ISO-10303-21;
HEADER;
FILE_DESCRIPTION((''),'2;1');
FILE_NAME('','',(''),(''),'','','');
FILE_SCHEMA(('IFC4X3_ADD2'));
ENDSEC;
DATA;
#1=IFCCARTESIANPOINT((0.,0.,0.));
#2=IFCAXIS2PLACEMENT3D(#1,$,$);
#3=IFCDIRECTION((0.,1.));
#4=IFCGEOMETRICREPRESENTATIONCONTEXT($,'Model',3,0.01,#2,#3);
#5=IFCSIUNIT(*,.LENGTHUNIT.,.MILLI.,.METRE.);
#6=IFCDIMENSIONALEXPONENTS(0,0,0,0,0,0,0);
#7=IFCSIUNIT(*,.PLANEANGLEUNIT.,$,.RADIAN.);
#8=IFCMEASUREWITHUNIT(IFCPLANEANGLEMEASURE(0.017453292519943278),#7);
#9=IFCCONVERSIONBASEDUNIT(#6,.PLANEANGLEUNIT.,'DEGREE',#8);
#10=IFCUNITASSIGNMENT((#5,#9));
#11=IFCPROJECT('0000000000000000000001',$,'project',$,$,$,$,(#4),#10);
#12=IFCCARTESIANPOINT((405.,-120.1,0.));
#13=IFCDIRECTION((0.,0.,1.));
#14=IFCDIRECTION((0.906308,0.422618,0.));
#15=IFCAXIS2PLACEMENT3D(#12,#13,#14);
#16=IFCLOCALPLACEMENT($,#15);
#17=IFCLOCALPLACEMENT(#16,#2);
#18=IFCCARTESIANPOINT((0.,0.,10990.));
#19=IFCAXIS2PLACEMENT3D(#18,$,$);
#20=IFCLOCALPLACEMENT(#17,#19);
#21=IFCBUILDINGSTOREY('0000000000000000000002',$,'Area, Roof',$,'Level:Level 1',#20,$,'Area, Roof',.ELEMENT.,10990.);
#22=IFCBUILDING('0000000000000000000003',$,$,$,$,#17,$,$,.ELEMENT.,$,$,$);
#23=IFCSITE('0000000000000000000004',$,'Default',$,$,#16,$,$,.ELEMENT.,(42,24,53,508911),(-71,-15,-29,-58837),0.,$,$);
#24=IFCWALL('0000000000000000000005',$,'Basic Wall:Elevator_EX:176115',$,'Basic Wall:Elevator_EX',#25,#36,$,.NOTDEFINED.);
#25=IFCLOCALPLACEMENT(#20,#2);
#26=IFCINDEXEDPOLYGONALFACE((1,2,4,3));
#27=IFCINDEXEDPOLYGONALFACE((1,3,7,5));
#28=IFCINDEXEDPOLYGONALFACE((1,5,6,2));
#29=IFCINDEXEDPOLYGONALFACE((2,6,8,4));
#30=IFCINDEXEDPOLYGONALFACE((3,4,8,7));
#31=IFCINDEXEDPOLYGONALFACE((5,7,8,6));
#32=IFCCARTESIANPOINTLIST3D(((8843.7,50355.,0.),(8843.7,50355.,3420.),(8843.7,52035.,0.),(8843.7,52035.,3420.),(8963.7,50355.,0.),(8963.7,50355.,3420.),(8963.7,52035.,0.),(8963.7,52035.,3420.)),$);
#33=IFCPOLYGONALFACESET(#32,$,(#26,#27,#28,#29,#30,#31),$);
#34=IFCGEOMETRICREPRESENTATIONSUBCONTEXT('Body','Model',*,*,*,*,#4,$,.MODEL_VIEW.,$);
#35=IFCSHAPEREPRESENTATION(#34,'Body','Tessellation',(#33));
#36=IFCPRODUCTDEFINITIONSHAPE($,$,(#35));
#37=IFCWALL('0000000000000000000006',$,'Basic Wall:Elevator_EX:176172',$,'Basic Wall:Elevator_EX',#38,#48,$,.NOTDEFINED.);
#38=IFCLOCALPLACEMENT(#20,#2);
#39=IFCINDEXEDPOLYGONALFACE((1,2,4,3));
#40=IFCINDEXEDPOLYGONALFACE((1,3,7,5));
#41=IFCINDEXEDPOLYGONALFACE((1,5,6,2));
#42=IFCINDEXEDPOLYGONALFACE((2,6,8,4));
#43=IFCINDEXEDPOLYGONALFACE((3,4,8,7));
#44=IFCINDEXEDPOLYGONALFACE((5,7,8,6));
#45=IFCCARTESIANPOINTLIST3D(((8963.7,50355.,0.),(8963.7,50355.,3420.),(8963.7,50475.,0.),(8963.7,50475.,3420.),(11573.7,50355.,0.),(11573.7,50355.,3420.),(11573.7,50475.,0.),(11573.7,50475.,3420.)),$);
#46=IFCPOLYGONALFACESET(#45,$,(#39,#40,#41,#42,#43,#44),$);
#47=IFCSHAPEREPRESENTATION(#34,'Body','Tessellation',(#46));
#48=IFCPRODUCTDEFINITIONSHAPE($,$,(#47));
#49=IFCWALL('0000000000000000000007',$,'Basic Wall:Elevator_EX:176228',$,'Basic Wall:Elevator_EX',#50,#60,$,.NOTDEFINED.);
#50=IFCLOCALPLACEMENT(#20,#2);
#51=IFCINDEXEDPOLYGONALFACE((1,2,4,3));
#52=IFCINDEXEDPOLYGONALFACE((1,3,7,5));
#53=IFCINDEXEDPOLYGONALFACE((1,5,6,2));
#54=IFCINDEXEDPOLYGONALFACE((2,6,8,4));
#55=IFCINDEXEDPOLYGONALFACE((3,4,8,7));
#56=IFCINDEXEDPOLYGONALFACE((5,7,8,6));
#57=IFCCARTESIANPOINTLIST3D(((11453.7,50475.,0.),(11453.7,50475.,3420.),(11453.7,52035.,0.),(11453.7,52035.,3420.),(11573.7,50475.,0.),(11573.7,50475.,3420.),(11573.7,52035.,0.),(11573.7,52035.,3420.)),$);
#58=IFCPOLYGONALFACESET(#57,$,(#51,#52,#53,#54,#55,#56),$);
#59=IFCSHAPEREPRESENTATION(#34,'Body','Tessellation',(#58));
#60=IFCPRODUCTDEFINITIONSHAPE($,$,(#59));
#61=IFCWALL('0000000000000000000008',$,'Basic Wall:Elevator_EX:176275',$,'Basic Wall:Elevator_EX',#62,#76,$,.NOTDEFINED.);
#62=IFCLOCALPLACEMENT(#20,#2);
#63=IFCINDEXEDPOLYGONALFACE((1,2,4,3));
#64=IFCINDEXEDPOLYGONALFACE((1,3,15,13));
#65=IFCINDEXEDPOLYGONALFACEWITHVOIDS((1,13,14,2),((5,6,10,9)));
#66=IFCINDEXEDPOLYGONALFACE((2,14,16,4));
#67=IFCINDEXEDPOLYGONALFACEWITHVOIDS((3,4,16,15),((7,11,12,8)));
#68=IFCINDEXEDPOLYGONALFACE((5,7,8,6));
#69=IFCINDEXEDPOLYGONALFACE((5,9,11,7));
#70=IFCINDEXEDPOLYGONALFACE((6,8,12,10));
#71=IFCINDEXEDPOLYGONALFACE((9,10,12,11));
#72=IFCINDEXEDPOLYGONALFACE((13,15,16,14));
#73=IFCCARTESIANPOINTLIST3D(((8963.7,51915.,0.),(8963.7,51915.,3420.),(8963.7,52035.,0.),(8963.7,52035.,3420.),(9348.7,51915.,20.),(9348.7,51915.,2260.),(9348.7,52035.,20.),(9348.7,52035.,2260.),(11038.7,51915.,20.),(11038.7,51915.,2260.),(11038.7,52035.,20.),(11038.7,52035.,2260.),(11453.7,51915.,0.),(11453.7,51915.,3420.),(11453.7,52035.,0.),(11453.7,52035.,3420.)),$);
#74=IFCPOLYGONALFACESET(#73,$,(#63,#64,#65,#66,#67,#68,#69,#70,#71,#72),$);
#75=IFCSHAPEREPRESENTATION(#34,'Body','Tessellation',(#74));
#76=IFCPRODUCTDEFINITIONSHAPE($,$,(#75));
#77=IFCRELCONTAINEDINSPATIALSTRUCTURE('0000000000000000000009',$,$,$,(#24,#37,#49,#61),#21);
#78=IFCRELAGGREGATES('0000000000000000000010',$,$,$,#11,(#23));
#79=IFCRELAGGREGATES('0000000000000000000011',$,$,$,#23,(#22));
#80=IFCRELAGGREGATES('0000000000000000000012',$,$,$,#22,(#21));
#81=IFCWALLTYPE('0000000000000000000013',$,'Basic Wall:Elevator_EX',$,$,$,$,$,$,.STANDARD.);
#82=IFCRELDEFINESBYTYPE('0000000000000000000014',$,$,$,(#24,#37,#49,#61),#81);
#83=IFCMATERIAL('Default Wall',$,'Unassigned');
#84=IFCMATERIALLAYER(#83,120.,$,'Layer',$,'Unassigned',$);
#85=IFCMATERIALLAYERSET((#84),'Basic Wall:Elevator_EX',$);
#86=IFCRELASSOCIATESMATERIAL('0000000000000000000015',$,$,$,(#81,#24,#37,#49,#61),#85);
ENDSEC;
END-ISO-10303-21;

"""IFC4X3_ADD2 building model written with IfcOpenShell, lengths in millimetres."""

from ifc_helpers import new_model, entity, si_unit, converted_unit, direction, frame, frame_2d, origin, place, context, subcontext, project, spatial, rectangle, extrude, material, layer, layer_set, type_object, element, save


model = new_model("IFC4X3_ADD2")

# Units and contexts
model_context = context("Model", 3, precision=0.01, world=origin(), true_north=direction((0.0, 1.0)))
body_context = subcontext(model_context, "Body", "Model", "MODEL_VIEW")
ifc_project = project(units=[si_unit("LENGTHUNIT", "METRE", prefix="MILLI"), converted_unit("PLANEANGLEUNIT", "DEGREE", entity("IfcPlaneAngleMeasure", 0.017453292519943278), si_unit("PLANEANGLEUNIT", "RADIAN"), dimensions=[0, 0, 0, 0, 0, 0, 0])], contexts=[model_context])

# Site, building, storey
site_placement = place(None, frame((405.0, -120.1, 0.0), z_axis=(0.0, 0.0, 1.0), x_axis=(0.906308, 0.422618, 0.0)))
site = spatial("IfcSite", under=ifc_project, at=site_placement, Name="Default", CompositionType="ELEMENT", RefLatitude=(42, 24, 53, 508911), RefLongitude=(-71, -15, -29, -58837), RefElevation=0.0)
building_placement = place(site_placement, origin())
building = spatial("IfcBuilding", under=site, at=building_placement, CompositionType="ELEMENT")
storey_placement = place(building_placement, frame((0.0, 0.0, 10990.0)))
storey = spatial("IfcBuildingStorey", under=building, at=storey_placement, Name="Area, Roof", ObjectType="Level:Level 1", LongName="Area, Roof", CompositionType="ELEMENT", Elevation=10990.0)

# Shared definitions
ifc_material_1 = material(Name="Default Wall", Category="Unassigned")

# Walls
ifc_layer_1 = layer(ifc_material_1, 120.0, Name="Layer", Category="Unassigned")
ifc_layer_set_1 = layer_set([ifc_layer_1], Name="Basic Wall:Elevator_EX")
wall_type_1 = type_object("IfcWallType", Name="Basic Wall:Elevator_EX", PredefinedType="STANDARD", material=ifc_layer_set_1)
wall_1_placement = place(storey_placement, frame((8903.7, 52035.0, 0.0), z_axis=(0.0, 0.0, 1.0), x_axis=(0.0, -1.0, 0.0)))
element("IfcWall", 1, at=wall_1_placement, inside=storey, type_object=wall_type_1, material=ifc_layer_set_1, Name="Basic Wall:Elevator_EX:176115", ObjectType="Basic Wall:Elevator_EX", PredefinedType="NOTDEFINED", context=body_context, shape_type="SweptSolid", body=[
    extrude(rectangle(XDim=1680.0, YDim=120.0, at=frame_2d((840.0, 0.0), x_axis=(-1.0, 0.0))), origin(), (0.0, 0.0, 1.0), 3420.0),
])
wall_2_placement = place(storey_placement, frame((8963.7, 50415.0, 0.0)))
element("IfcWall", 2, at=wall_2_placement, inside=storey, type_object=wall_type_1, material=ifc_layer_set_1, Name="Basic Wall:Elevator_EX:176172", ObjectType="Basic Wall:Elevator_EX", PredefinedType="NOTDEFINED", context=body_context, shape_type="SweptSolid", body=[
    extrude(rectangle(XDim=2610.0, YDim=120.0, at=frame_2d((1305.0, 0.0), x_axis=(-1.0, 0.0))), origin(), (0.0, 0.0, 1.0), 3420.0),
])
wall_3_placement = place(storey_placement, frame((11513.7, 52035.0, 0.0), z_axis=(0.0, 0.0, 1.0), x_axis=(0.0, -1.0, 0.0)))
element("IfcWall", 3, at=wall_3_placement, inside=storey, type_object=wall_type_1, material=ifc_layer_set_1, Name="Basic Wall:Elevator_EX:176228", ObjectType="Basic Wall:Elevator_EX", PredefinedType="NOTDEFINED", context=body_context, shape_type="SweptSolid", body=[
    extrude(rectangle(XDim=1560.0, YDim=120.0, at=frame_2d((780.0, 0.0), x_axis=(-1.0, 0.0))), origin(), (0.0, 0.0, 1.0), 3420.0),
])

# Wall, opening
wall_4_placement = place(storey_placement, frame((8963.7, 51975.0, 0.0)))
wall_4 = element("IfcWall", 4, at=wall_4_placement, inside=storey, type_object=wall_type_1, material=ifc_layer_set_1, Name="Basic Wall:Elevator_EX:176275", ObjectType="Basic Wall:Elevator_EX", PredefinedType="NOTDEFINED", context=body_context, shape_type="SweptSolid", body=[
    extrude(rectangle(XDim=2490.0, YDim=120.0, at=frame_2d((1245.0, 0.0), x_axis=(-1.0, 0.0))), origin(), (0.0, 0.0, 1.0), 3420.0),
])
opening_1_placement = place(wall_4_placement, frame((385.0, -60.0, 20.0)))
element("IfcOpeningElement", 5, at=opening_1_placement, cuts=wall_4, PredefinedType="OPENING", context=body_context, shape_type="SweptSolid", body=[
    extrude(rectangle(XDim=2240.0, YDim=1690.0, at=frame_2d((0.0, 0.0), x_axis=(1.0, 0.0))), frame((845.0, 0.0, 1120.0), z_axis=(0.0, 1.0, 0.0), x_axis=(0.0, 0.0, -1.0)), (0.0, 0.0, 1.0), 120.0),
])

save(model, "model.ifc")
